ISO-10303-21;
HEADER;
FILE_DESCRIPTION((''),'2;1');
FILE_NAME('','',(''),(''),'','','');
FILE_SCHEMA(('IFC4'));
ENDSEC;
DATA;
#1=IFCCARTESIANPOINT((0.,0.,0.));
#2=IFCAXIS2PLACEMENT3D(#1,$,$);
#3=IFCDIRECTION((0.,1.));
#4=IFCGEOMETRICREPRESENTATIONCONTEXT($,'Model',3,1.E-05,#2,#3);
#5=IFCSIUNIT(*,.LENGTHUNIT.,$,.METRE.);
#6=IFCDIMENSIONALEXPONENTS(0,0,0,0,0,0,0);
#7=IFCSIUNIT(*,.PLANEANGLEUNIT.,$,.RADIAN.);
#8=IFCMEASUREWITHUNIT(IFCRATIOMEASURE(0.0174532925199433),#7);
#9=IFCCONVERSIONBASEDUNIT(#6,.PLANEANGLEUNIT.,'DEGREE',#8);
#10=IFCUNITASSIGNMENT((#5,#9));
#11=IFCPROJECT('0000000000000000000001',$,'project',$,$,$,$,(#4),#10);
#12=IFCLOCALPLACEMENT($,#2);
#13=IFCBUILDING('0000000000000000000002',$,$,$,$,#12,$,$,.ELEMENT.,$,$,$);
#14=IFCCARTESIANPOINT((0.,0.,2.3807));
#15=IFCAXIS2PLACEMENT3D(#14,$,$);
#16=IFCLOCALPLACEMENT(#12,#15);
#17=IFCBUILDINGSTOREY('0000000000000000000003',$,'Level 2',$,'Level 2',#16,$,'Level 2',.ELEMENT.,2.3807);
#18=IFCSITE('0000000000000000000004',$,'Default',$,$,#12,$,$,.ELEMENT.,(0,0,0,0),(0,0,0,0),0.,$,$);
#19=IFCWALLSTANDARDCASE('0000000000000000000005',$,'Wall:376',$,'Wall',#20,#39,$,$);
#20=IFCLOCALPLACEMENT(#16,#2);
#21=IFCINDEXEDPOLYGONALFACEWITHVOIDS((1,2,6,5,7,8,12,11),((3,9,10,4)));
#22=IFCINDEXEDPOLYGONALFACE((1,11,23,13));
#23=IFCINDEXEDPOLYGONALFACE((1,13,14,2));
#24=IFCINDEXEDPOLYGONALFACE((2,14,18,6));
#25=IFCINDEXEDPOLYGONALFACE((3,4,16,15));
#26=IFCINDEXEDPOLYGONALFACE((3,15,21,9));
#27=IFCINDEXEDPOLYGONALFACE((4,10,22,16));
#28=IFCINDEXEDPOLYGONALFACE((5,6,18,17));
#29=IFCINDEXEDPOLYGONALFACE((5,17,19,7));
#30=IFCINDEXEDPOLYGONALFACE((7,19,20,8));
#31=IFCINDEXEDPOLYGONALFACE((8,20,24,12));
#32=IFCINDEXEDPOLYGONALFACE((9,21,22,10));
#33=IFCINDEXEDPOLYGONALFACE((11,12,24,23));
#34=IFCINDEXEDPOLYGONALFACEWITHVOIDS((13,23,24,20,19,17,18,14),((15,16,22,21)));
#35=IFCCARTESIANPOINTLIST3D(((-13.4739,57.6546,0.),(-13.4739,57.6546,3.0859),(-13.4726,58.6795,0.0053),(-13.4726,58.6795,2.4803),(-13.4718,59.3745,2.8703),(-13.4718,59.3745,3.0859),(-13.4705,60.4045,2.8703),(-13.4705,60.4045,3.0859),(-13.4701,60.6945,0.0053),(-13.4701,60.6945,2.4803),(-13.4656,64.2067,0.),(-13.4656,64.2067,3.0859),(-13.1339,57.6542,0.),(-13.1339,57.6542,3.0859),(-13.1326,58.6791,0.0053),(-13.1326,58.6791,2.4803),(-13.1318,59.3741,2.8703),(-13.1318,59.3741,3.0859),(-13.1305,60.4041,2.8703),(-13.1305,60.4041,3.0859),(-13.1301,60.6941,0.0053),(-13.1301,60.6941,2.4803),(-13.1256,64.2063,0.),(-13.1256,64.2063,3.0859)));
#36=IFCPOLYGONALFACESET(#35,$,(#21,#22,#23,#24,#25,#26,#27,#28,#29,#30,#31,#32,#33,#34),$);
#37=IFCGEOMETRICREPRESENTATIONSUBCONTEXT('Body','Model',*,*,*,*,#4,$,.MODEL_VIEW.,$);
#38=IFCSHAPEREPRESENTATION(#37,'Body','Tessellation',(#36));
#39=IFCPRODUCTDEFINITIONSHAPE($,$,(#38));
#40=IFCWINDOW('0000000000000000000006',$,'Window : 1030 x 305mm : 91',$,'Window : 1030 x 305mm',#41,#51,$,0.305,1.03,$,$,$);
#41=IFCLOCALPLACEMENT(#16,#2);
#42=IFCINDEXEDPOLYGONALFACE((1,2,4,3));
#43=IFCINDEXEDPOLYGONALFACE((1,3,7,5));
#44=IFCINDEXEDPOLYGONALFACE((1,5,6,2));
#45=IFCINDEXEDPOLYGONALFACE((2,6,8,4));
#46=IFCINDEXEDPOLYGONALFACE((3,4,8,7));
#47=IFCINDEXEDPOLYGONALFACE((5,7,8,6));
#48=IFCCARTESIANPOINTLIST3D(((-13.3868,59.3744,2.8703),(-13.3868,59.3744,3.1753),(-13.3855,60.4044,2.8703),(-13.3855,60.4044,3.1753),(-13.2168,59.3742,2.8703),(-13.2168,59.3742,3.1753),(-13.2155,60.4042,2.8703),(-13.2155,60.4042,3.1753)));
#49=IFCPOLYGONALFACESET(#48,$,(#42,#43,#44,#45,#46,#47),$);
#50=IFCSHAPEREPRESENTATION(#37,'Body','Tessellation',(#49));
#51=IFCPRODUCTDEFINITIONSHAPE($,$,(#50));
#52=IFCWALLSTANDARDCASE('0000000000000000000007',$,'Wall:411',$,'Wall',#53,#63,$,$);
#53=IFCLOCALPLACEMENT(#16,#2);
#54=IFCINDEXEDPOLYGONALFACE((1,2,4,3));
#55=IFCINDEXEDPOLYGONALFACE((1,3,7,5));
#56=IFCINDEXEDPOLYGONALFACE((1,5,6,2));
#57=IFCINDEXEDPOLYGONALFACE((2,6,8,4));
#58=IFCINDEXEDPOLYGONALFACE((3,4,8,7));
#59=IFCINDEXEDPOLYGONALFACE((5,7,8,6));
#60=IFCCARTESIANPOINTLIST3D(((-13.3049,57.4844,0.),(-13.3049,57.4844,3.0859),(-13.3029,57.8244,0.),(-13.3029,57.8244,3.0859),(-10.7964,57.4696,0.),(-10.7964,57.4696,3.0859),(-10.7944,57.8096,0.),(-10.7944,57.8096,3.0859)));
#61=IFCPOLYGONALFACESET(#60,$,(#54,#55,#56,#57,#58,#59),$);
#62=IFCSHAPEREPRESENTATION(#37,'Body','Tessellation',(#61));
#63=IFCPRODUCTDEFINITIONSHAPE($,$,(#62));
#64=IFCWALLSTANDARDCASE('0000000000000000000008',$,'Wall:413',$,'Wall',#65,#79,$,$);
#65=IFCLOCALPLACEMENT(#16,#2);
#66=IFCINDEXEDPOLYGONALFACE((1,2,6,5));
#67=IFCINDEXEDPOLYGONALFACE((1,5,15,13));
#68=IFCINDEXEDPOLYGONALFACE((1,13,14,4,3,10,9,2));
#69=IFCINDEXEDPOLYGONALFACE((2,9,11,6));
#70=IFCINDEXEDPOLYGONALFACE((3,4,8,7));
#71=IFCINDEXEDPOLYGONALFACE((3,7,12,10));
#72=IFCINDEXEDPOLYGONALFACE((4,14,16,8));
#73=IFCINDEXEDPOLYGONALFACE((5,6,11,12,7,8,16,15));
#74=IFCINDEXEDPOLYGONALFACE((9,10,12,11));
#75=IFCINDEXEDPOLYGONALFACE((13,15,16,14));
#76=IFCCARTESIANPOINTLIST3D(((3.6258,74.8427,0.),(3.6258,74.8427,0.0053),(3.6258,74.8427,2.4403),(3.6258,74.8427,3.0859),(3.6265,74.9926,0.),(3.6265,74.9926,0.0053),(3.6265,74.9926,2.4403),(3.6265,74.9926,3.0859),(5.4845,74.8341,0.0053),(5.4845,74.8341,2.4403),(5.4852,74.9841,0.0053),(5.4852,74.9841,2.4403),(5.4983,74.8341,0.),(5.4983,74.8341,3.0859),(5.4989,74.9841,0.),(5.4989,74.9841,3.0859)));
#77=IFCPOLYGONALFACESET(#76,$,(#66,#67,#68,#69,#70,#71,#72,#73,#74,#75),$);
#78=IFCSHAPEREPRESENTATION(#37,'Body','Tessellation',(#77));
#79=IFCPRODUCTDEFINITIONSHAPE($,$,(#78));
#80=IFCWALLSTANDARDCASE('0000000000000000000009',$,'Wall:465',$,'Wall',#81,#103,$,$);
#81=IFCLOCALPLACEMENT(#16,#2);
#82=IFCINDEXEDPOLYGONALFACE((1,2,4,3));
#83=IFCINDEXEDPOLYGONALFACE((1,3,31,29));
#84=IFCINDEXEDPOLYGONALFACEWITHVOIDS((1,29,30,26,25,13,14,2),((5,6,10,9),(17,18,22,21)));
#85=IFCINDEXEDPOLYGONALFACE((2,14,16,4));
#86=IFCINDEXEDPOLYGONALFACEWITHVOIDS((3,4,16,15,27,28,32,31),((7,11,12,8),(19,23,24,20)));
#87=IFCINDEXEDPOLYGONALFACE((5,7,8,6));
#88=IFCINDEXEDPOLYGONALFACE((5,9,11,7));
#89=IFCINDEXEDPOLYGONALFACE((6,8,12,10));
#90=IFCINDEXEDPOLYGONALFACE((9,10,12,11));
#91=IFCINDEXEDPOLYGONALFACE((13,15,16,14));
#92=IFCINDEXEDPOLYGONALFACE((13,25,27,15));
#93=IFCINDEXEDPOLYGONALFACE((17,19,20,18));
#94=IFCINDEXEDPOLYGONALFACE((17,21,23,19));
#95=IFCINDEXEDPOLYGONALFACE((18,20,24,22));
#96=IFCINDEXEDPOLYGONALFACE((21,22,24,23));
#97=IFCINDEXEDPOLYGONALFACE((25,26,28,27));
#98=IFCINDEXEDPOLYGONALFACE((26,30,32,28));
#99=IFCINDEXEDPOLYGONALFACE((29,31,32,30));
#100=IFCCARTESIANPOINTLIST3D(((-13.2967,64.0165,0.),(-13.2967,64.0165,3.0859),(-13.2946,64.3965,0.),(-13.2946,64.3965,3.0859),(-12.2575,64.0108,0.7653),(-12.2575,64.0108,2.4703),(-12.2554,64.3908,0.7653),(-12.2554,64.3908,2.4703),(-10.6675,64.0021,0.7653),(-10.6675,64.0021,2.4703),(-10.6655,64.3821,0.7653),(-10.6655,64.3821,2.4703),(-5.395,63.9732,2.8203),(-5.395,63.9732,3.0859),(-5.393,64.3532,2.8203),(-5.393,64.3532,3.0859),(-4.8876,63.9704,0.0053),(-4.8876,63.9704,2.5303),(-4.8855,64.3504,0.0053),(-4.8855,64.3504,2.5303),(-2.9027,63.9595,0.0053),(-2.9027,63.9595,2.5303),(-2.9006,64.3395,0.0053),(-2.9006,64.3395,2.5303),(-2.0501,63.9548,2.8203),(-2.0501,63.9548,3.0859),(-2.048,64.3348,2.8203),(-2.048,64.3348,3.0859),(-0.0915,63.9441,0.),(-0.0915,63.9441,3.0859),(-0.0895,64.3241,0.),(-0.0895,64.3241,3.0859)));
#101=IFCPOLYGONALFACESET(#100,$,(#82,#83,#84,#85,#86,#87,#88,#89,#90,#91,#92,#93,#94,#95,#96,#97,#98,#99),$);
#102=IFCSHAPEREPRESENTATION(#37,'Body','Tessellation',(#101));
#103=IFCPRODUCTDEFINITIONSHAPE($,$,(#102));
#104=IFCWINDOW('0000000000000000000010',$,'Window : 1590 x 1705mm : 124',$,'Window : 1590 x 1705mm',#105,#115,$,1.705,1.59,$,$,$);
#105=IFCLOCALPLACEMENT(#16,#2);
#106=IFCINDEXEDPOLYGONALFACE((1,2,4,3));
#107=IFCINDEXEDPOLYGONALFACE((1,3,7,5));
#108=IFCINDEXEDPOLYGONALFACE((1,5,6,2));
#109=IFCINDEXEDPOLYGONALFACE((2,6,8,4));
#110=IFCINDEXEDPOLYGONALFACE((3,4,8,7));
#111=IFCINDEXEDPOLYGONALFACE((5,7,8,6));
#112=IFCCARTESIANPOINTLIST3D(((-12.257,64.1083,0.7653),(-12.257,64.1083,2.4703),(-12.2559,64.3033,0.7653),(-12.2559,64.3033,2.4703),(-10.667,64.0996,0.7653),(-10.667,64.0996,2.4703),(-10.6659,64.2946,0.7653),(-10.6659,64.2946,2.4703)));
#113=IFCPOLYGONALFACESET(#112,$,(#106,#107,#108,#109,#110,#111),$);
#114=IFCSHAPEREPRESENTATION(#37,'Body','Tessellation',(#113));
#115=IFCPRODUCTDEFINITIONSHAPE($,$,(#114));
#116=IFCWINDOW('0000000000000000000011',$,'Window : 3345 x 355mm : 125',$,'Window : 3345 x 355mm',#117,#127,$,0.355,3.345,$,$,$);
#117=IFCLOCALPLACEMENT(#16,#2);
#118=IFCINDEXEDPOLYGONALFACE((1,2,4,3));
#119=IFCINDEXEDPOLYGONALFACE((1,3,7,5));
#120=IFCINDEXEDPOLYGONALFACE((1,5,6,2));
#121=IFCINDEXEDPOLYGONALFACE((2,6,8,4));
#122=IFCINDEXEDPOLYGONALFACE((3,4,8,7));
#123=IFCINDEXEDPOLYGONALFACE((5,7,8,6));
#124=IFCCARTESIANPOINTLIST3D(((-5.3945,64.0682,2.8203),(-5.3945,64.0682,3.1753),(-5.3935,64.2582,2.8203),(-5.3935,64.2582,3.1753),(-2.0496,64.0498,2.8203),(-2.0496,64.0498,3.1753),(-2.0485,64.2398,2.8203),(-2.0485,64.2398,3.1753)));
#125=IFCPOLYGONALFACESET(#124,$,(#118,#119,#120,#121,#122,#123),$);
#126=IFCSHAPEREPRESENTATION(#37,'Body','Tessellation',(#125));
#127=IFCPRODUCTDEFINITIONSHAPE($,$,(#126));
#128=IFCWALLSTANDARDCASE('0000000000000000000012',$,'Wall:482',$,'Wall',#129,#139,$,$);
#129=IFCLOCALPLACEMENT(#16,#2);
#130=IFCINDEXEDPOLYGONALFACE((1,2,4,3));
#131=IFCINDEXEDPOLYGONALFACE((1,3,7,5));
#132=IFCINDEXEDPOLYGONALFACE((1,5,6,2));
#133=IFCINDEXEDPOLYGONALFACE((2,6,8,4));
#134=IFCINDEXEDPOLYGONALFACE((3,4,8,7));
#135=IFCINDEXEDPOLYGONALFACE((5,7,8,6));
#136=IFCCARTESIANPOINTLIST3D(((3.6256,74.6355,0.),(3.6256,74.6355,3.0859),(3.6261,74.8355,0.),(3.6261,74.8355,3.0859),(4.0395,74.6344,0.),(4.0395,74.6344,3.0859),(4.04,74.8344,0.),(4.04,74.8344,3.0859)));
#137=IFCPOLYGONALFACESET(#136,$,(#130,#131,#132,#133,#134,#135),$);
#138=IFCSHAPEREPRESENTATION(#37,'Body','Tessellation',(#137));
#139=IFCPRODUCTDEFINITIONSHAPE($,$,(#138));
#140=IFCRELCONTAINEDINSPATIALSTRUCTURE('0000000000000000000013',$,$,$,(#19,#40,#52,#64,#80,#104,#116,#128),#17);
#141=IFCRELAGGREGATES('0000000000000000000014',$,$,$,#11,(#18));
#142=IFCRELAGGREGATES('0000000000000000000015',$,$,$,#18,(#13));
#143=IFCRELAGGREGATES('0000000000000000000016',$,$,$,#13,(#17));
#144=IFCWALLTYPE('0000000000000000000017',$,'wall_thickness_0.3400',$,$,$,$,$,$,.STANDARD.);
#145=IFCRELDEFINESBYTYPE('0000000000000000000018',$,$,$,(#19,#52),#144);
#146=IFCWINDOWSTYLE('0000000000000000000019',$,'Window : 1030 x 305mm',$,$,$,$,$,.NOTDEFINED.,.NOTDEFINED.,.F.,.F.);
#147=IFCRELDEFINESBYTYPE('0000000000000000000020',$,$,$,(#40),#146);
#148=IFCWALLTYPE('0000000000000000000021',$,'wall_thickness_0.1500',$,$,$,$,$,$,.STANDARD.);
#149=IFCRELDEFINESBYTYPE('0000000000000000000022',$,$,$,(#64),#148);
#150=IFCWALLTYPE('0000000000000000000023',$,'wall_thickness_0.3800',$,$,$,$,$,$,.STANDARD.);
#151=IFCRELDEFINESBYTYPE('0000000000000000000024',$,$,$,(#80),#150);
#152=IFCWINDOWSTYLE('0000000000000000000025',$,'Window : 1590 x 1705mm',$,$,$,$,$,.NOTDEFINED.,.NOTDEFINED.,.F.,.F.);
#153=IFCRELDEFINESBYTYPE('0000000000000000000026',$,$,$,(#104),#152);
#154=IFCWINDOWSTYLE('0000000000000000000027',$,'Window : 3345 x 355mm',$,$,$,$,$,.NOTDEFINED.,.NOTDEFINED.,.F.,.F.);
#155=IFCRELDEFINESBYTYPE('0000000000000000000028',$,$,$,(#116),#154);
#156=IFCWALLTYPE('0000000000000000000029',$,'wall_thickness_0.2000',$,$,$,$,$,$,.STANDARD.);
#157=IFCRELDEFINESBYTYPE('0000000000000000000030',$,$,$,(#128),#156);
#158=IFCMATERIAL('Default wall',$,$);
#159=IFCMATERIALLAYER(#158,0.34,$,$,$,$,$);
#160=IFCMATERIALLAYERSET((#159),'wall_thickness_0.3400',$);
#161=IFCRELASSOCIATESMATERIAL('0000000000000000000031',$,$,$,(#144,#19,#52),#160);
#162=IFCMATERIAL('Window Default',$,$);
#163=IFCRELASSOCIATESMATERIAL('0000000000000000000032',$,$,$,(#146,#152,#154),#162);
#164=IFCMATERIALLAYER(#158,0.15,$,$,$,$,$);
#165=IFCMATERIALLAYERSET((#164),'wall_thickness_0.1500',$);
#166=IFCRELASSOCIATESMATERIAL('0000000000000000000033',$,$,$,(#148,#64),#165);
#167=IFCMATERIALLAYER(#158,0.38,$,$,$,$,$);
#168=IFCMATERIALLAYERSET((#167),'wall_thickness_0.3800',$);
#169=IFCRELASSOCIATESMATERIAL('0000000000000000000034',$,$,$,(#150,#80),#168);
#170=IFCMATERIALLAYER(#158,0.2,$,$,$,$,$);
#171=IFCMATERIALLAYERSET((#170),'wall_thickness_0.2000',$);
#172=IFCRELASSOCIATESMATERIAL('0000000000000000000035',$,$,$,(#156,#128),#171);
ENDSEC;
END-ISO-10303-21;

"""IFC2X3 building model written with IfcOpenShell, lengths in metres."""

from ifc_helpers import new_model, entity, si_unit, converted_unit, direction, frame, frame_2d, origin, origin_2d_with_axis, place, context, subcontext, project, spatial, polyline, rectangle, outline, extrude, source, transform, mapped, material, layer, layer_set, layer_usage, type_object, type_shapes, element, fill, save


model = new_model("IFC2X3")

# Units and contexts
model_context = context("Model", 3, precision=1e-05, world=origin(), true_north=direction((0.0, 1.0)))
body_context = subcontext(model_context, "Body", "Model", "MODEL_VIEW")
ifc_project = project(units=[si_unit("LENGTHUNIT", "METRE"), converted_unit("PLANEANGLEUNIT", "DEGREE", entity("IfcRatioMeasure", 0.0174532925199433), si_unit("PLANEANGLEUNIT", "RADIAN"), dimensions=[0, 0, 0, 0, 0, 0, 0])], contexts=[model_context])

# Site, building, storey
placement_1 = place(None, origin())
site = spatial("IfcSite", under=ifc_project, at=placement_1, Name="Default", CompositionType="ELEMENT", RefLatitude=(0, 0, 0, 0), RefLongitude=(0, 0, 0, 0), RefElevation=0.0)
building = spatial("IfcBuilding", under=site, at=placement_1, CompositionType="ELEMENT")
storey_placement = place(placement_1, frame((0.0, 0.0, 2.3807)))
storey = spatial("IfcBuildingStorey", under=building, at=storey_placement, Name="Level 2", ObjectType="Level 2", LongName="Level 2", CompositionType="ELEMENT", Elevation=2.3807)

# Shared definitions
ifc_material_1 = material(Name="Default wall")
ifc_material_2 = material(Name="Window Default")

# Wall, openings, window
ifc_layer_1 = layer(ifc_material_1, 0.34)
ifc_layer_set_1 = layer_set([ifc_layer_1], Name="wall_thickness_0.3400")
ifc_layer_usage_1 = layer_usage(ifc_layer_set_1, "AXIS2", "POSITIVE", -0.17)
wall_type_1 = type_object("IfcWallType", Name="wall_thickness_0.3400", PredefinedType="STANDARD", material=ifc_layer_set_1)
wall_1_placement = place(storey_placement, frame((-13.2956, 64.2065, 0.0), z_axis=(0.0, 0.0, 1.0), x_axis=(-0.001267, -0.999999, 0.0)))
wall_1 = element("IfcWallStandardCase", 1, at=wall_1_placement, inside=storey, type_object=wall_type_1, material=ifc_layer_usage_1, Name="Wall:376", ObjectType="Wall", context=body_context, shape_type="SweptSolid", body=[
    extrude(outline(polyline([(6.5522, -0.17), (6.5522, 0.17), (0.0, 0.17), (0.0, -0.17), (6.5522, -0.17)])), origin(), (0.0, 0.0, 1.0), 3.0859),
])
opening_1_placement = place(wall_1_placement, frame((3.5122, -0.17, 0.0053)))
element("IfcOpeningElement", 2, at=opening_1_placement, cuts=wall_1, ObjectType="Opening", context=body_context, shape_type="SweptSolid", body=[
    extrude(rectangle(XDim=2.015, YDim=2.475, at=frame_2d((1.2375, 1.0075), x_axis=(0.0, 1.0))), frame((0.0, 0.0, 0.0), z_axis=(0.0, 1.0, 0.0), x_axis=(0.0, 0.0, 1.0)), (0.0, 0.0, 1.0), 0.34),
])
opening_2_placement = place(wall_1_placement, frame((3.8022, -0.17, 2.8703)))
opening_2 = element("IfcOpeningElement", 3, at=opening_2_placement, cuts=wall_1, ObjectType="Opening", context=body_context, shape_type="SweptSolid", body=[
    extrude(rectangle(XDim=1.03, YDim=0.305, at=frame_2d((0.1525, 0.515), x_axis=(0.0, 1.0))), frame((0.0, 0.0, 0.0), z_axis=(0.0, 1.0, 0.0), x_axis=(0.0, 0.0, 1.0)), (0.0, 0.0, 1.0), 0.34),
])
window_style_1 = type_object("IfcWindowStyle", Name="Window : 1030 x 305mm", ConstructionType="NOTDEFINED", OperationType="NOTDEFINED", ParameterTakesPrecedence=False, Sizeable=False, material=ifc_material_2)
shared_shape_1 = source(origin(), body_context, "Body", "SweptSolid", [
    extrude(rectangle(XDim=0.17, YDim=1.03, at=origin_2d_with_axis()), frame((0.515, 0.17, 0.0), z_axis=(0.0, 0.0, 1.0), x_axis=(0.0, 1.0, 0.0)), (0.0, 0.0, 1.0), 0.305),
])
type_shapes(window_style_1, [shared_shape_1])
window_1_placement = place(opening_2_placement, origin())
window_1 = element("IfcWindow", 4, at=window_1_placement, inside=storey, type_object=window_style_1, Name="Window : 1030 x 305mm : 91", ObjectType="Window : 1030 x 305mm", OverallHeight=0.305, OverallWidth=1.03, context=body_context, shape_type="MappedRepresentation", body=[
    mapped(shared_shape_1, transform((0.0, 0.0, 0.0), scale=1.0)),
])
fill(opening_2, window_1)

# Wall
wall_2_placement = place(storey_placement, frame((-13.3039, 57.6544, 0.0), z_axis=(0.0, 0.0, 1.0), x_axis=(0.999983, -0.005879, 0.0)))
element("IfcWallStandardCase", 5, at=wall_2_placement, inside=storey, type_object=wall_type_1, material=ifc_layer_usage_1, Name="Wall:411", ObjectType="Wall", context=body_context, shape_type="SweptSolid", body=[
    extrude(outline(polyline([(2.5086, -0.17), (2.5086, 0.17), (0.0, 0.17), (0.0, -0.17), (2.5086, -0.17)])), origin(), (0.0, 0.0, 1.0), 3.0859),
])

# Wall, opening
ifc_layer_2 = layer(ifc_material_1, 0.15)
ifc_layer_set_2 = layer_set([ifc_layer_2], Name="wall_thickness_0.1500")
ifc_layer_usage_2 = layer_usage(ifc_layer_set_2, "AXIS2", "POSITIVE", -0.075)
wall_type_2 = type_object("IfcWallType", Name="wall_thickness_0.1500", PredefinedType="STANDARD", material=ifc_layer_set_2)
wall_3_placement = place(storey_placement, frame((3.6262, 74.9177, 0.0), z_axis=(0.0, 0.0, 1.0), x_axis=(0.999989, -0.004584, 0.0)))
wall_3 = element("IfcWallStandardCase", 6, at=wall_3_placement, inside=storey, type_object=wall_type_2, material=ifc_layer_usage_2, Name="Wall:413", ObjectType="Wall", context=body_context, shape_type="SweptSolid", body=[
    extrude(outline(polyline([(1.8724, -0.075), (1.8724, 0.075), (0.0, 0.075), (0.0, -0.075), (1.8724, -0.075)])), origin(), (0.0, 0.0, 1.0), 3.0859),
])
opening_3_placement = place(wall_3_placement, frame((-0.1213, -0.075, 0.0053)))
element("IfcOpeningElement", 7, at=opening_3_placement, cuts=wall_3, ObjectType="Opening", context=body_context, shape_type="SweptSolid", body=[
    extrude(rectangle(XDim=1.98, YDim=2.435, at=frame_2d((1.2175, 0.99), x_axis=(0.0, 1.0))), frame((0.0, 0.0, 0.0), z_axis=(0.0, 1.0, 0.0), x_axis=(0.0, 0.0, 1.0)), (0.0, 0.0, 1.0), 0.15),
])

# Wall, openings, windows
ifc_layer_3 = layer(ifc_material_1, 0.38)
ifc_layer_set_3 = layer_set([ifc_layer_3], Name="wall_thickness_0.3800")
ifc_layer_usage_3 = layer_usage(ifc_layer_set_3, "AXIS2", "POSITIVE", -0.19)
wall_type_3 = type_object("IfcWallType", Name="wall_thickness_0.3800", PredefinedType="STANDARD", material=ifc_layer_set_3)
wall_4_placement = place(storey_placement, frame((-13.2956, 64.2065, 0.0), z_axis=(0.0, 0.0, 1.0), x_axis=(0.999985, -0.005486, 0.0)))
wall_4 = element("IfcWallStandardCase", 8, at=wall_4_placement, inside=storey, type_object=wall_type_3, material=ifc_layer_usage_3, Name="Wall:465", ObjectType="Wall", context=body_context, shape_type="SweptSolid", body=[
    extrude(outline(polyline([(13.2053, -0.19), (13.2053, 0.19), (0.0, 0.19), (0.0, -0.19), (13.2053, -0.19)])), origin(), (0.0, 0.0, 1.0), 3.0859),
])
opening_4_placement = place(wall_4_placement, frame((8.4092, -0.19, 0.0053)))
element("IfcOpeningElement", 9, at=opening_4_placement, cuts=wall_4, ObjectType="Opening", context=body_context, shape_type="SweptSolid", body=[
    extrude(rectangle(XDim=1.985, YDim=2.525, at=frame_2d((1.2625, 0.9925), x_axis=(0.0, 1.0))), frame((0.0, 0.0, 0.0), z_axis=(0.0, 1.0, 0.0), x_axis=(0.0, 0.0, 1.0)), (0.0, 0.0, 1.0), 0.38),
])
opening_5_placement = place(wall_4_placement, frame((1.0392, -0.19, 0.7653)))
opening_5 = element("IfcOpeningElement", 10, at=opening_5_placement, cuts=wall_4, ObjectType="Opening", context=body_context, shape_type="SweptSolid", body=[
    extrude(rectangle(XDim=1.59, YDim=1.705, at=frame_2d((0.8525, 0.795), x_axis=(0.0, 1.0))), frame((0.0, 0.0, 0.0), z_axis=(0.0, 1.0, 0.0), x_axis=(0.0, 0.0, 1.0)), (0.0, 0.0, 1.0), 0.38),
])
opening_6_placement = place(wall_4_placement, frame((7.9018, -0.19, 2.8203)))
opening_6 = element("IfcOpeningElement", 11, at=opening_6_placement, cuts=wall_4, ObjectType="Opening", context=body_context, shape_type="SweptSolid", body=[
    extrude(rectangle(XDim=3.345, YDim=0.355, at=frame_2d((0.1775, 1.6725), x_axis=(0.0, 1.0))), frame((0.0, 0.0, 0.0), z_axis=(0.0, 1.0, 0.0), x_axis=(0.0, 0.0, 1.0)), (0.0, 0.0, 1.0), 0.38),
])
window_style_2 = type_object("IfcWindowStyle", Name="Window : 1590 x 1705mm", ConstructionType="NOTDEFINED", OperationType="NOTDEFINED", ParameterTakesPrecedence=False, Sizeable=False, material=ifc_material_2)
shared_shape_2 = source(origin(), body_context, "Body", "SweptSolid", [
    extrude(rectangle(XDim=0.195, YDim=1.59, at=origin_2d_with_axis()), frame((0.795, 0.195, 0.0), z_axis=(0.0, 0.0, 1.0), x_axis=(0.0, 1.0, 0.0)), (0.0, 0.0, 1.0), 1.705),
])
type_shapes(window_style_2, [shared_shape_2])
window_2_placement = place(opening_5_placement, origin())
window_2 = element("IfcWindow", 12, at=window_2_placement, inside=storey, type_object=window_style_2, Name="Window : 1590 x 1705mm : 124", ObjectType="Window : 1590 x 1705mm", OverallHeight=1.705, OverallWidth=1.59, context=body_context, shape_type="MappedRepresentation", body=[
    mapped(shared_shape_2, transform((0.0, 0.0, 0.0), scale=1.0)),
])
fill(opening_5, window_2)
window_style_3 = type_object("IfcWindowStyle", Name="Window : 3345 x 355mm", ConstructionType="NOTDEFINED", OperationType="NOTDEFINED", ParameterTakesPrecedence=False, Sizeable=False, material=ifc_material_2)
shared_shape_3 = source(origin(), body_context, "Body", "SweptSolid", [
    extrude(rectangle(XDim=0.19, YDim=3.345, at=origin_2d_with_axis()), frame((1.6725, 0.19, 0.0), z_axis=(0.0, 0.0, 1.0), x_axis=(0.0, 1.0, 0.0)), (0.0, 0.0, 1.0), 0.355),
])
type_shapes(window_style_3, [shared_shape_3])
window_3_placement = place(opening_6_placement, origin())
window_3 = element("IfcWindow", 13, at=window_3_placement, inside=storey, type_object=window_style_3, Name="Window : 3345 x 355mm : 125", ObjectType="Window : 3345 x 355mm", OverallHeight=0.355, OverallWidth=3.345, context=body_context, shape_type="MappedRepresentation", body=[
    mapped(shared_shape_3, transform((0.0, 0.0, 0.0), scale=1.0)),
])
fill(opening_6, window_3)

# Wall
ifc_layer_4 = layer(ifc_material_1, 0.2)
ifc_layer_set_4 = layer_set([ifc_layer_4], Name="wall_thickness_0.2000")
ifc_layer_usage_4 = layer_usage(ifc_layer_set_4, "AXIS2", "POSITIVE", -0.1)
wall_type_4 = type_object("IfcWallType", Name="wall_thickness_0.2000", PredefinedType="STANDARD", material=ifc_layer_set_4)
wall_5_placement = place(storey_placement, frame((3.6259, 74.7355, 0.0), z_axis=(0.0, 0.0, 1.0), x_axis=(0.999997, -0.002636, 0.0)))
element("IfcWallStandardCase", 14, at=wall_5_placement, inside=storey, type_object=wall_type_4, material=ifc_layer_usage_4, Name="Wall:482", ObjectType="Wall", context=body_context, shape_type="SweptSolid", body=[
    extrude(outline(polyline([(0.4139, -0.1), (0.4139, 0.1), (0.0, 0.1), (0.0, -0.1), (0.4139, -0.1)])), origin(), (0.0, 0.0, 1.0), 3.0859),
])

save(model, "model.ifc")
